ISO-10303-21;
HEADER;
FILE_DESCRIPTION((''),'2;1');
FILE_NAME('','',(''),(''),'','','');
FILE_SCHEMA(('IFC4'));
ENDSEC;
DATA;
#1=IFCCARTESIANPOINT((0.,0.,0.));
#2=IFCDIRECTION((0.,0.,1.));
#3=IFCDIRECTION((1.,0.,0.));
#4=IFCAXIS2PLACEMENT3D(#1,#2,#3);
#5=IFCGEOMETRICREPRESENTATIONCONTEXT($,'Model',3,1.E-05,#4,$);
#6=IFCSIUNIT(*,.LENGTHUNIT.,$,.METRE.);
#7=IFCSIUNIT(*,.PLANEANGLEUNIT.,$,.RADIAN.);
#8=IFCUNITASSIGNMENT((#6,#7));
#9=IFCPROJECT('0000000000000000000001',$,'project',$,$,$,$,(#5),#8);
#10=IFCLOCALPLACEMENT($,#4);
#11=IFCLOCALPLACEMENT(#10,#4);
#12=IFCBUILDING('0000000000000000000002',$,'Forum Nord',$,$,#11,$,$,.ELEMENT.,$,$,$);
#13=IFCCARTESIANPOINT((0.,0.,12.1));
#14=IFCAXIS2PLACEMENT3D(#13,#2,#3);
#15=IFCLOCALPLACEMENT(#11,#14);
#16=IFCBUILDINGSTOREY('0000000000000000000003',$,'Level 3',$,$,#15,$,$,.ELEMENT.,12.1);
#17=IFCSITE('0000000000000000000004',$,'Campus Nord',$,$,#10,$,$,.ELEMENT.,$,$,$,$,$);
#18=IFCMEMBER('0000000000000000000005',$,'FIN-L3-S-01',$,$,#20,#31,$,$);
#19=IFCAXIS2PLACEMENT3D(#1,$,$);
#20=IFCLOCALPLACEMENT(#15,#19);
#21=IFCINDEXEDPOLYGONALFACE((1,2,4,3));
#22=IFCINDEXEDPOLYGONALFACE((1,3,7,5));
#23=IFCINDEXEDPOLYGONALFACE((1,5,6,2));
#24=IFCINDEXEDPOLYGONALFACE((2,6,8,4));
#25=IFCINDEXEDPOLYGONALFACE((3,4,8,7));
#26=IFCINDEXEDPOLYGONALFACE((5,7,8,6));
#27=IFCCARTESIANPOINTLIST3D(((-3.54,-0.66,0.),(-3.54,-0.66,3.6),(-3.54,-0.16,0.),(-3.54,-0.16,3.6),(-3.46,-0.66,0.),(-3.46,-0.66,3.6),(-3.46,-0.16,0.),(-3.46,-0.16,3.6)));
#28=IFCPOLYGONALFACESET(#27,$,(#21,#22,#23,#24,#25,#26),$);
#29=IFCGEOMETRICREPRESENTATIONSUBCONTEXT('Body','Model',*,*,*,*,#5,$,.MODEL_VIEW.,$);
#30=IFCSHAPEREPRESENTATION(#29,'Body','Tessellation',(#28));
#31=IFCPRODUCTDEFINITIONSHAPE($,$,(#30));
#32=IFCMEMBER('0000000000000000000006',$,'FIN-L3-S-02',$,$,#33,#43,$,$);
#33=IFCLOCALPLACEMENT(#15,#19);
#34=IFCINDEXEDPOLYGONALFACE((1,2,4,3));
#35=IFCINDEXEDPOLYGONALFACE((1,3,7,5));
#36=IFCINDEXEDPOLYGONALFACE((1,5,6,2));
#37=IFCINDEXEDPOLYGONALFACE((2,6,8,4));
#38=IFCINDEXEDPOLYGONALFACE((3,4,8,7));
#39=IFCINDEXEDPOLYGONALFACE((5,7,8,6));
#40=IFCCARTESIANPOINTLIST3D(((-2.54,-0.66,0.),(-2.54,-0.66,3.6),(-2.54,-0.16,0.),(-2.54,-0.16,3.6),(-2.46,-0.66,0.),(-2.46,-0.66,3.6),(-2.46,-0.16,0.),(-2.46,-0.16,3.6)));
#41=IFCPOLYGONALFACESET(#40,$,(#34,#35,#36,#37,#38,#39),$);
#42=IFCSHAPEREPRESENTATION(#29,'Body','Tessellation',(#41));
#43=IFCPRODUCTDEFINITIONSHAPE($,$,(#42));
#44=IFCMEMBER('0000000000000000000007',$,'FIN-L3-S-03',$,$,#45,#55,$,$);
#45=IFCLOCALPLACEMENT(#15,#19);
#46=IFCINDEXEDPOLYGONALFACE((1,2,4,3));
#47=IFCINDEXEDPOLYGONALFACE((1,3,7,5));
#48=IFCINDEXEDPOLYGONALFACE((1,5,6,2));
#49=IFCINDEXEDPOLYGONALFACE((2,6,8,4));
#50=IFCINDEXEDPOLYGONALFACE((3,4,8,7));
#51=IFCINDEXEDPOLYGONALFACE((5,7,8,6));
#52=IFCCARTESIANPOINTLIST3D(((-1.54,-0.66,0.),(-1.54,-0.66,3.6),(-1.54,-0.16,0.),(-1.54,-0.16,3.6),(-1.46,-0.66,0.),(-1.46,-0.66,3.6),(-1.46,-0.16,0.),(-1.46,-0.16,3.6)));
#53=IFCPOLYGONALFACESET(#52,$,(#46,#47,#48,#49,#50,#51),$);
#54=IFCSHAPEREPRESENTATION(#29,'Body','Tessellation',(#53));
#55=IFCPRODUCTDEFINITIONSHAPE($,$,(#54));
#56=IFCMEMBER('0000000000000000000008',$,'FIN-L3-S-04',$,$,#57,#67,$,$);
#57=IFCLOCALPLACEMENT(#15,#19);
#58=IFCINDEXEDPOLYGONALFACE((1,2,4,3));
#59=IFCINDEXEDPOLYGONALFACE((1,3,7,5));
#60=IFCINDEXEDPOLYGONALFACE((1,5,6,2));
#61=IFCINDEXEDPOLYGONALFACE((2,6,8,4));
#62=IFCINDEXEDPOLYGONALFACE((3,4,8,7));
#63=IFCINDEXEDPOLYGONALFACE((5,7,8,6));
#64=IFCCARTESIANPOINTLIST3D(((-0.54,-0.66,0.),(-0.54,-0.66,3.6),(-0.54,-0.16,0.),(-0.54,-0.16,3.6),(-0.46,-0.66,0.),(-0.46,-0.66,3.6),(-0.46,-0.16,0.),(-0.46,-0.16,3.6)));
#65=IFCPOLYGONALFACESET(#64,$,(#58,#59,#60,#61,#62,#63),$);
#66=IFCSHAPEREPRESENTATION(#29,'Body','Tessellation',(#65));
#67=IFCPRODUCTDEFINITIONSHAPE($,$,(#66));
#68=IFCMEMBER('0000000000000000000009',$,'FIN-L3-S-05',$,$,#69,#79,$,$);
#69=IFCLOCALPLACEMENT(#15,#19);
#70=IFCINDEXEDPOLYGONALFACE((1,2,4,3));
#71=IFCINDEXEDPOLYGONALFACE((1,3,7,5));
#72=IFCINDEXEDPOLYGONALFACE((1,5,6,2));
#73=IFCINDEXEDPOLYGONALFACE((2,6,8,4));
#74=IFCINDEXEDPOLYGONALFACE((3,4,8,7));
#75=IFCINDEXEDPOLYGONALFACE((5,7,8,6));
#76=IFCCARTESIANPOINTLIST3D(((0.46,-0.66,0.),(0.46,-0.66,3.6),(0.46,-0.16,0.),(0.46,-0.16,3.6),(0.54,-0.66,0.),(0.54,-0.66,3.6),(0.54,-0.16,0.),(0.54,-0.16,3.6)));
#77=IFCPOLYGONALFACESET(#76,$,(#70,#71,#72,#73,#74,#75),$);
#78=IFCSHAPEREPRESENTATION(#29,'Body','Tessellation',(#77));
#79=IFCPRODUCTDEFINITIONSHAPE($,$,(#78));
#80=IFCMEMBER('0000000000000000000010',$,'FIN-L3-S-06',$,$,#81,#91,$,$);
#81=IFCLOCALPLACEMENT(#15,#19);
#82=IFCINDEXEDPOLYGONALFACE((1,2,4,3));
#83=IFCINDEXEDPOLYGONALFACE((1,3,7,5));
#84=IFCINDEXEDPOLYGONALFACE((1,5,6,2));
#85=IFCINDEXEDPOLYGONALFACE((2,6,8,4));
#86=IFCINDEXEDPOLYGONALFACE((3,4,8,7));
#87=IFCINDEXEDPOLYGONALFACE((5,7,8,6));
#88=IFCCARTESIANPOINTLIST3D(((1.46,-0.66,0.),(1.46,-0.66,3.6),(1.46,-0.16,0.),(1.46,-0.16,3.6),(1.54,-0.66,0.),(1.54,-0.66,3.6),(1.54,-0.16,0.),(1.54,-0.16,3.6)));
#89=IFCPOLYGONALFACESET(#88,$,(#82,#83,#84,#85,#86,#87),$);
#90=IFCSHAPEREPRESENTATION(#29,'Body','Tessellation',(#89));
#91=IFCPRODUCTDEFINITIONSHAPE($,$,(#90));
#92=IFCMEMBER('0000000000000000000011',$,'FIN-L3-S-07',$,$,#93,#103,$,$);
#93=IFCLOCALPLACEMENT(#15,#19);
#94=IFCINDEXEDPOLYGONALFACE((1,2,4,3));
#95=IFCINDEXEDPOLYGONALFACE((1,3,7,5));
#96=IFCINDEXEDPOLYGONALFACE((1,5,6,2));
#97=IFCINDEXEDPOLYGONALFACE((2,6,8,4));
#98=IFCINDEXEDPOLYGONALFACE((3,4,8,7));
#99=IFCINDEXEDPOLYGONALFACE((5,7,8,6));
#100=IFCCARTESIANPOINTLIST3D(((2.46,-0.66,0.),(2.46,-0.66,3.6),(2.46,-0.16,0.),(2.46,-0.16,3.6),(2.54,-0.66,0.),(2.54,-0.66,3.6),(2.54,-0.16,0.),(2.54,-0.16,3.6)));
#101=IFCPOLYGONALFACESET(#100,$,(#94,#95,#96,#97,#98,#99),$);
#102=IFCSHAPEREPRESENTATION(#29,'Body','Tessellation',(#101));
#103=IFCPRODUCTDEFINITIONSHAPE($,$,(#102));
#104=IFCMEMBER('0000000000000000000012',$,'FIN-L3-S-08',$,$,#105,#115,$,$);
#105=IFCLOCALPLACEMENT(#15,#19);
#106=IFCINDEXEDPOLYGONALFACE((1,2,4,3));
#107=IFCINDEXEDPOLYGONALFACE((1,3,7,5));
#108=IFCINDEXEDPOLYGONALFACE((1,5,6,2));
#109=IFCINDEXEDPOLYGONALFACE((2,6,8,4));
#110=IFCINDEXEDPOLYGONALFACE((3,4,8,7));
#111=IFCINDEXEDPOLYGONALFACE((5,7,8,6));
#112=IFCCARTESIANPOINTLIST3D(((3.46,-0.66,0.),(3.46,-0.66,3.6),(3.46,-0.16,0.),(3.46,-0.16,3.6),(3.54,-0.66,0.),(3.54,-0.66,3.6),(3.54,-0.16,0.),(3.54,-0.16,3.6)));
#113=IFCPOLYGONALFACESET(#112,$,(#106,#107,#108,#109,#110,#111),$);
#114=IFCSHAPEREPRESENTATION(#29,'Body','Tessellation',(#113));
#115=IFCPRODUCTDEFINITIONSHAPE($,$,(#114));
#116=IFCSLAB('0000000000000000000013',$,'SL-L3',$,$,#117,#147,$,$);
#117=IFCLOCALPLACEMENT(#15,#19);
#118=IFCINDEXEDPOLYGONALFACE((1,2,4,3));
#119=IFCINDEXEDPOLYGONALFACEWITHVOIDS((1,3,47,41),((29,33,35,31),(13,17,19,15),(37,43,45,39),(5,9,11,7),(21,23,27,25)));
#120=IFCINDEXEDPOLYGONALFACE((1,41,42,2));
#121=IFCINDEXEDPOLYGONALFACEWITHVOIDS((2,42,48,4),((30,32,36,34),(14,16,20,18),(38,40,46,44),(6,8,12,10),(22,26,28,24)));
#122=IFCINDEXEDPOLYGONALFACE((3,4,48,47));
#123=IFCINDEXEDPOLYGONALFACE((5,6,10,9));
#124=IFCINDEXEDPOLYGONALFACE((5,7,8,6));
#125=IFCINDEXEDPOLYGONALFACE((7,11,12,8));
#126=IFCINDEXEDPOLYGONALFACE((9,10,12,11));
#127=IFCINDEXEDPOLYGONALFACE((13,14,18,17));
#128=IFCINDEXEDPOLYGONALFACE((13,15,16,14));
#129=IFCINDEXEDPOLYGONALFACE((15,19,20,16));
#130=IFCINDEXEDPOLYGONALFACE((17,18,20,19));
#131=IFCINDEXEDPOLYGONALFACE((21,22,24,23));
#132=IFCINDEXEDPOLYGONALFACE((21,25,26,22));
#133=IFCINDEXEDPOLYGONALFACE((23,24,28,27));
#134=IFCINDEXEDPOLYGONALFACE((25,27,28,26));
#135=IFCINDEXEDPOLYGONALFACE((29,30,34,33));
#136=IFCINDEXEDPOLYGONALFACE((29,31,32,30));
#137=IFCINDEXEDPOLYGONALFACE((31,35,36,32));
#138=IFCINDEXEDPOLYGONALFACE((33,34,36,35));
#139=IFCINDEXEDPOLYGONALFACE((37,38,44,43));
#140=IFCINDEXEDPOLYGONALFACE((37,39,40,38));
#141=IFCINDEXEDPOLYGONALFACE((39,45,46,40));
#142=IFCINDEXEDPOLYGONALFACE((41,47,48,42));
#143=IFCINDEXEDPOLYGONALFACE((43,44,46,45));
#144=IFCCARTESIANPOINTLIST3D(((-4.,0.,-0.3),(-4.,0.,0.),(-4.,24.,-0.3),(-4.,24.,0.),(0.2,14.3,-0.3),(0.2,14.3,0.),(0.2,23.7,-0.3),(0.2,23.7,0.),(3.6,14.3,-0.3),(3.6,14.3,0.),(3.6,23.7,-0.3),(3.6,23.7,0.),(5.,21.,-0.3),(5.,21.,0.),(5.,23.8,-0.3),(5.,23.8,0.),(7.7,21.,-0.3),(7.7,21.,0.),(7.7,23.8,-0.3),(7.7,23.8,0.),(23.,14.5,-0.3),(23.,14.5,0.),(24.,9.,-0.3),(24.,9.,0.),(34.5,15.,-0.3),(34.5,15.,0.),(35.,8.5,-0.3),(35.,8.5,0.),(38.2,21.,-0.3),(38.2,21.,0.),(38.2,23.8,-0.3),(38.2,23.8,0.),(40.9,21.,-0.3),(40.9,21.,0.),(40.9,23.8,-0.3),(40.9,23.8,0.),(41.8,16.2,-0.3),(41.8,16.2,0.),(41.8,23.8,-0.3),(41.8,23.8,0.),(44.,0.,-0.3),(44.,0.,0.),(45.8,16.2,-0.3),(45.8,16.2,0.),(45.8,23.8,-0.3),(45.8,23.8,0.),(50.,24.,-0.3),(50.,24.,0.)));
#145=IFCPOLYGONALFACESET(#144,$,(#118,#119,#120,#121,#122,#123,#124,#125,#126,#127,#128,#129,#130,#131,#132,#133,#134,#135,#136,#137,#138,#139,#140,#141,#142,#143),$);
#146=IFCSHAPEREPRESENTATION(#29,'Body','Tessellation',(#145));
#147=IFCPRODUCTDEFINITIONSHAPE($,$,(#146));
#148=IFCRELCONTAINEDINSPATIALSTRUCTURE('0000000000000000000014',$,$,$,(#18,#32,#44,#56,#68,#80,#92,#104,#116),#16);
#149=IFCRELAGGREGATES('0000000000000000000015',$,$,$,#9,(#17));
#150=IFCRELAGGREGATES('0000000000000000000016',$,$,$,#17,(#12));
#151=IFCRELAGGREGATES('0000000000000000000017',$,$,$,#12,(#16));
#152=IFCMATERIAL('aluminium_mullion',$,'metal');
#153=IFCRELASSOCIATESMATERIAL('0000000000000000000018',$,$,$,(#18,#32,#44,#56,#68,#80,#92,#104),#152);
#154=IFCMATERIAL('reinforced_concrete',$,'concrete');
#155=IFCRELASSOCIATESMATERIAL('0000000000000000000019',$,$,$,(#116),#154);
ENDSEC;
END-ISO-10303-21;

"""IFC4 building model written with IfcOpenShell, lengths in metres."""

from ifc_helpers import new_model, si_unit, frame, origin_with_axes, place, context, subcontext, project, spatial, polyline, outline, extrude, material, element, save


model = new_model("IFC4")

# Units and contexts
model_context = context("Model", 3, precision=1e-05, world=origin_with_axes())
body_context = subcontext(model_context, "Body", "Model", "MODEL_VIEW")
ifc_project = project(units=[si_unit("LENGTHUNIT", "METRE"), si_unit("PLANEANGLEUNIT", "RADIAN")], contexts=[model_context])

# Site, building, storey
site_placement = place(None, origin_with_axes())
site = spatial("IfcSite", under=ifc_project, at=site_placement, Name="Campus Nord", CompositionType="ELEMENT")
building_placement = place(site_placement, origin_with_axes())
building = spatial("IfcBuilding", under=site, at=building_placement, Name="Forum Nord", CompositionType="ELEMENT")
storey_placement = place(building_placement, frame((0.0, 0.0, 12.1), z_axis=(0.0, 0.0, 1.0), x_axis=(1.0, 0.0, 0.0)))
storey = spatial("IfcBuildingStorey", under=building, at=storey_placement, Name="Level 3", CompositionType="ELEMENT", Elevation=12.1)

# Members
ifc_material_1 = material(Name="aluminium_mullion", Category="metal")
member_1_placement = place(storey_placement, origin_with_axes())
element("IfcMember", 1, at=member_1_placement, inside=storey, material=ifc_material_1, Name="FIN-L3-S-01", context=body_context, shape_type="SweptSolid", body=[
    extrude(outline(polyline([(-3.54, -0.66), (-3.46, -0.66), (-3.46, -0.16), (-3.54, -0.16), (-3.54, -0.66)])), origin_with_axes(), (0.0, 0.0, 1.0), 3.6),
])
member_2_placement = place(storey_placement, origin_with_axes())
element("IfcMember", 2, at=member_2_placement, inside=storey, material=ifc_material_1, Name="FIN-L3-S-02", context=body_context, shape_type="SweptSolid", body=[
    extrude(outline(polyline([(-2.54, -0.66), (-2.46, -0.66), (-2.46, -0.16), (-2.54, -0.16), (-2.54, -0.66)])), origin_with_axes(), (0.0, 0.0, 1.0), 3.6),
])
member_3_placement = place(storey_placement, origin_with_axes())
element("IfcMember", 3, at=member_3_placement, inside=storey, material=ifc_material_1, Name="FIN-L3-S-03", context=body_context, shape_type="SweptSolid", body=[
    extrude(outline(polyline([(-1.54, -0.66), (-1.46, -0.66), (-1.46, -0.16), (-1.54, -0.16), (-1.54, -0.66)])), origin_with_axes(), (0.0, 0.0, 1.0), 3.6),
])
member_4_placement = place(storey_placement, origin_with_axes())
element("IfcMember", 4, at=member_4_placement, inside=storey, material=ifc_material_1, Name="FIN-L3-S-04", context=body_context, shape_type="SweptSolid", body=[
    extrude(outline(polyline([(-0.54, -0.66), (-0.46, -0.66), (-0.46, -0.16), (-0.54, -0.16), (-0.54, -0.66)])), origin_with_axes(), (0.0, 0.0, 1.0), 3.6),
])
member_5_placement = place(storey_placement, origin_with_axes())
element("IfcMember", 5, at=member_5_placement, inside=storey, material=ifc_material_1, Name="FIN-L3-S-05", context=body_context, shape_type="SweptSolid", body=[
    extrude(outline(polyline([(0.46, -0.66), (0.54, -0.66), (0.54, -0.16), (0.46, -0.16), (0.46, -0.66)])), origin_with_axes(), (0.0, 0.0, 1.0), 3.6),
])
member_6_placement = place(storey_placement, origin_with_axes())
element("IfcMember", 6, at=member_6_placement, inside=storey, material=ifc_material_1, Name="FIN-L3-S-06", context=body_context, shape_type="SweptSolid", body=[
    extrude(outline(polyline([(1.46, -0.66), (1.54, -0.66), (1.54, -0.16), (1.46, -0.16), (1.46, -0.66)])), origin_with_axes(), (0.0, 0.0, 1.0), 3.6),
])
member_7_placement = place(storey_placement, origin_with_axes())
element("IfcMember", 7, at=member_7_placement, inside=storey, material=ifc_material_1, Name="FIN-L3-S-07", context=body_context, shape_type="SweptSolid", body=[
    extrude(outline(polyline([(2.46, -0.66), (2.54, -0.66), (2.54, -0.16), (2.46, -0.16), (2.46, -0.66)])), origin_with_axes(), (0.0, 0.0, 1.0), 3.6),
])
member_8_placement = place(storey_placement, origin_with_axes())
element("IfcMember", 8, at=member_8_placement, inside=storey, material=ifc_material_1, Name="FIN-L3-S-08", context=body_context, shape_type="SweptSolid", body=[
    extrude(outline(polyline([(3.46, -0.66), (3.54, -0.66), (3.54, -0.16), (3.46, -0.16), (3.46, -0.66)])), origin_with_axes(), (0.0, 0.0, 1.0), 3.6),
])

# Slab
ifc_material_2 = material(Name="reinforced_concrete", Category="concrete")
slab_placement = place(storey_placement, origin_with_axes())
element("IfcSlab", 9, at=slab_placement, inside=storey, material=ifc_material_2, Name="SL-L3", context=body_context, shape_type="SweptSolid", body=[
    extrude(outline(polyline([(-4.0, 0.0), (44.0, 0.0), (50.0, 24.0), (-4.0, 24.0), (-4.0, 0.0)]), holes=[polyline([(24.0, 9.0), (35.0, 8.5), (34.5, 15.0), (23.0, 14.5), (24.0, 9.0)]), polyline([(0.2, 14.3), (3.6, 14.3), (3.6, 23.7), (0.2, 23.7), (0.2, 14.3)]), polyline([(5.0, 21.0), (7.7, 21.0), (7.7, 23.8), (5.0, 23.8), (5.0, 21.0)]), polyline([(41.8, 16.2), (45.8, 16.2), (45.8, 23.8), (41.8, 23.8), (41.8, 16.2)]), polyline([(38.2, 21.0), (40.9, 21.0), (40.9, 23.8), (38.2, 23.8), (38.2, 21.0)])]), frame((0.0, 0.0, -0.3), z_axis=(0.0, 0.0, 1.0), x_axis=(1.0, 0.0, 0.0)), (0.0, 0.0, 1.0), 0.3),
])

save(model, "model.ifc")
